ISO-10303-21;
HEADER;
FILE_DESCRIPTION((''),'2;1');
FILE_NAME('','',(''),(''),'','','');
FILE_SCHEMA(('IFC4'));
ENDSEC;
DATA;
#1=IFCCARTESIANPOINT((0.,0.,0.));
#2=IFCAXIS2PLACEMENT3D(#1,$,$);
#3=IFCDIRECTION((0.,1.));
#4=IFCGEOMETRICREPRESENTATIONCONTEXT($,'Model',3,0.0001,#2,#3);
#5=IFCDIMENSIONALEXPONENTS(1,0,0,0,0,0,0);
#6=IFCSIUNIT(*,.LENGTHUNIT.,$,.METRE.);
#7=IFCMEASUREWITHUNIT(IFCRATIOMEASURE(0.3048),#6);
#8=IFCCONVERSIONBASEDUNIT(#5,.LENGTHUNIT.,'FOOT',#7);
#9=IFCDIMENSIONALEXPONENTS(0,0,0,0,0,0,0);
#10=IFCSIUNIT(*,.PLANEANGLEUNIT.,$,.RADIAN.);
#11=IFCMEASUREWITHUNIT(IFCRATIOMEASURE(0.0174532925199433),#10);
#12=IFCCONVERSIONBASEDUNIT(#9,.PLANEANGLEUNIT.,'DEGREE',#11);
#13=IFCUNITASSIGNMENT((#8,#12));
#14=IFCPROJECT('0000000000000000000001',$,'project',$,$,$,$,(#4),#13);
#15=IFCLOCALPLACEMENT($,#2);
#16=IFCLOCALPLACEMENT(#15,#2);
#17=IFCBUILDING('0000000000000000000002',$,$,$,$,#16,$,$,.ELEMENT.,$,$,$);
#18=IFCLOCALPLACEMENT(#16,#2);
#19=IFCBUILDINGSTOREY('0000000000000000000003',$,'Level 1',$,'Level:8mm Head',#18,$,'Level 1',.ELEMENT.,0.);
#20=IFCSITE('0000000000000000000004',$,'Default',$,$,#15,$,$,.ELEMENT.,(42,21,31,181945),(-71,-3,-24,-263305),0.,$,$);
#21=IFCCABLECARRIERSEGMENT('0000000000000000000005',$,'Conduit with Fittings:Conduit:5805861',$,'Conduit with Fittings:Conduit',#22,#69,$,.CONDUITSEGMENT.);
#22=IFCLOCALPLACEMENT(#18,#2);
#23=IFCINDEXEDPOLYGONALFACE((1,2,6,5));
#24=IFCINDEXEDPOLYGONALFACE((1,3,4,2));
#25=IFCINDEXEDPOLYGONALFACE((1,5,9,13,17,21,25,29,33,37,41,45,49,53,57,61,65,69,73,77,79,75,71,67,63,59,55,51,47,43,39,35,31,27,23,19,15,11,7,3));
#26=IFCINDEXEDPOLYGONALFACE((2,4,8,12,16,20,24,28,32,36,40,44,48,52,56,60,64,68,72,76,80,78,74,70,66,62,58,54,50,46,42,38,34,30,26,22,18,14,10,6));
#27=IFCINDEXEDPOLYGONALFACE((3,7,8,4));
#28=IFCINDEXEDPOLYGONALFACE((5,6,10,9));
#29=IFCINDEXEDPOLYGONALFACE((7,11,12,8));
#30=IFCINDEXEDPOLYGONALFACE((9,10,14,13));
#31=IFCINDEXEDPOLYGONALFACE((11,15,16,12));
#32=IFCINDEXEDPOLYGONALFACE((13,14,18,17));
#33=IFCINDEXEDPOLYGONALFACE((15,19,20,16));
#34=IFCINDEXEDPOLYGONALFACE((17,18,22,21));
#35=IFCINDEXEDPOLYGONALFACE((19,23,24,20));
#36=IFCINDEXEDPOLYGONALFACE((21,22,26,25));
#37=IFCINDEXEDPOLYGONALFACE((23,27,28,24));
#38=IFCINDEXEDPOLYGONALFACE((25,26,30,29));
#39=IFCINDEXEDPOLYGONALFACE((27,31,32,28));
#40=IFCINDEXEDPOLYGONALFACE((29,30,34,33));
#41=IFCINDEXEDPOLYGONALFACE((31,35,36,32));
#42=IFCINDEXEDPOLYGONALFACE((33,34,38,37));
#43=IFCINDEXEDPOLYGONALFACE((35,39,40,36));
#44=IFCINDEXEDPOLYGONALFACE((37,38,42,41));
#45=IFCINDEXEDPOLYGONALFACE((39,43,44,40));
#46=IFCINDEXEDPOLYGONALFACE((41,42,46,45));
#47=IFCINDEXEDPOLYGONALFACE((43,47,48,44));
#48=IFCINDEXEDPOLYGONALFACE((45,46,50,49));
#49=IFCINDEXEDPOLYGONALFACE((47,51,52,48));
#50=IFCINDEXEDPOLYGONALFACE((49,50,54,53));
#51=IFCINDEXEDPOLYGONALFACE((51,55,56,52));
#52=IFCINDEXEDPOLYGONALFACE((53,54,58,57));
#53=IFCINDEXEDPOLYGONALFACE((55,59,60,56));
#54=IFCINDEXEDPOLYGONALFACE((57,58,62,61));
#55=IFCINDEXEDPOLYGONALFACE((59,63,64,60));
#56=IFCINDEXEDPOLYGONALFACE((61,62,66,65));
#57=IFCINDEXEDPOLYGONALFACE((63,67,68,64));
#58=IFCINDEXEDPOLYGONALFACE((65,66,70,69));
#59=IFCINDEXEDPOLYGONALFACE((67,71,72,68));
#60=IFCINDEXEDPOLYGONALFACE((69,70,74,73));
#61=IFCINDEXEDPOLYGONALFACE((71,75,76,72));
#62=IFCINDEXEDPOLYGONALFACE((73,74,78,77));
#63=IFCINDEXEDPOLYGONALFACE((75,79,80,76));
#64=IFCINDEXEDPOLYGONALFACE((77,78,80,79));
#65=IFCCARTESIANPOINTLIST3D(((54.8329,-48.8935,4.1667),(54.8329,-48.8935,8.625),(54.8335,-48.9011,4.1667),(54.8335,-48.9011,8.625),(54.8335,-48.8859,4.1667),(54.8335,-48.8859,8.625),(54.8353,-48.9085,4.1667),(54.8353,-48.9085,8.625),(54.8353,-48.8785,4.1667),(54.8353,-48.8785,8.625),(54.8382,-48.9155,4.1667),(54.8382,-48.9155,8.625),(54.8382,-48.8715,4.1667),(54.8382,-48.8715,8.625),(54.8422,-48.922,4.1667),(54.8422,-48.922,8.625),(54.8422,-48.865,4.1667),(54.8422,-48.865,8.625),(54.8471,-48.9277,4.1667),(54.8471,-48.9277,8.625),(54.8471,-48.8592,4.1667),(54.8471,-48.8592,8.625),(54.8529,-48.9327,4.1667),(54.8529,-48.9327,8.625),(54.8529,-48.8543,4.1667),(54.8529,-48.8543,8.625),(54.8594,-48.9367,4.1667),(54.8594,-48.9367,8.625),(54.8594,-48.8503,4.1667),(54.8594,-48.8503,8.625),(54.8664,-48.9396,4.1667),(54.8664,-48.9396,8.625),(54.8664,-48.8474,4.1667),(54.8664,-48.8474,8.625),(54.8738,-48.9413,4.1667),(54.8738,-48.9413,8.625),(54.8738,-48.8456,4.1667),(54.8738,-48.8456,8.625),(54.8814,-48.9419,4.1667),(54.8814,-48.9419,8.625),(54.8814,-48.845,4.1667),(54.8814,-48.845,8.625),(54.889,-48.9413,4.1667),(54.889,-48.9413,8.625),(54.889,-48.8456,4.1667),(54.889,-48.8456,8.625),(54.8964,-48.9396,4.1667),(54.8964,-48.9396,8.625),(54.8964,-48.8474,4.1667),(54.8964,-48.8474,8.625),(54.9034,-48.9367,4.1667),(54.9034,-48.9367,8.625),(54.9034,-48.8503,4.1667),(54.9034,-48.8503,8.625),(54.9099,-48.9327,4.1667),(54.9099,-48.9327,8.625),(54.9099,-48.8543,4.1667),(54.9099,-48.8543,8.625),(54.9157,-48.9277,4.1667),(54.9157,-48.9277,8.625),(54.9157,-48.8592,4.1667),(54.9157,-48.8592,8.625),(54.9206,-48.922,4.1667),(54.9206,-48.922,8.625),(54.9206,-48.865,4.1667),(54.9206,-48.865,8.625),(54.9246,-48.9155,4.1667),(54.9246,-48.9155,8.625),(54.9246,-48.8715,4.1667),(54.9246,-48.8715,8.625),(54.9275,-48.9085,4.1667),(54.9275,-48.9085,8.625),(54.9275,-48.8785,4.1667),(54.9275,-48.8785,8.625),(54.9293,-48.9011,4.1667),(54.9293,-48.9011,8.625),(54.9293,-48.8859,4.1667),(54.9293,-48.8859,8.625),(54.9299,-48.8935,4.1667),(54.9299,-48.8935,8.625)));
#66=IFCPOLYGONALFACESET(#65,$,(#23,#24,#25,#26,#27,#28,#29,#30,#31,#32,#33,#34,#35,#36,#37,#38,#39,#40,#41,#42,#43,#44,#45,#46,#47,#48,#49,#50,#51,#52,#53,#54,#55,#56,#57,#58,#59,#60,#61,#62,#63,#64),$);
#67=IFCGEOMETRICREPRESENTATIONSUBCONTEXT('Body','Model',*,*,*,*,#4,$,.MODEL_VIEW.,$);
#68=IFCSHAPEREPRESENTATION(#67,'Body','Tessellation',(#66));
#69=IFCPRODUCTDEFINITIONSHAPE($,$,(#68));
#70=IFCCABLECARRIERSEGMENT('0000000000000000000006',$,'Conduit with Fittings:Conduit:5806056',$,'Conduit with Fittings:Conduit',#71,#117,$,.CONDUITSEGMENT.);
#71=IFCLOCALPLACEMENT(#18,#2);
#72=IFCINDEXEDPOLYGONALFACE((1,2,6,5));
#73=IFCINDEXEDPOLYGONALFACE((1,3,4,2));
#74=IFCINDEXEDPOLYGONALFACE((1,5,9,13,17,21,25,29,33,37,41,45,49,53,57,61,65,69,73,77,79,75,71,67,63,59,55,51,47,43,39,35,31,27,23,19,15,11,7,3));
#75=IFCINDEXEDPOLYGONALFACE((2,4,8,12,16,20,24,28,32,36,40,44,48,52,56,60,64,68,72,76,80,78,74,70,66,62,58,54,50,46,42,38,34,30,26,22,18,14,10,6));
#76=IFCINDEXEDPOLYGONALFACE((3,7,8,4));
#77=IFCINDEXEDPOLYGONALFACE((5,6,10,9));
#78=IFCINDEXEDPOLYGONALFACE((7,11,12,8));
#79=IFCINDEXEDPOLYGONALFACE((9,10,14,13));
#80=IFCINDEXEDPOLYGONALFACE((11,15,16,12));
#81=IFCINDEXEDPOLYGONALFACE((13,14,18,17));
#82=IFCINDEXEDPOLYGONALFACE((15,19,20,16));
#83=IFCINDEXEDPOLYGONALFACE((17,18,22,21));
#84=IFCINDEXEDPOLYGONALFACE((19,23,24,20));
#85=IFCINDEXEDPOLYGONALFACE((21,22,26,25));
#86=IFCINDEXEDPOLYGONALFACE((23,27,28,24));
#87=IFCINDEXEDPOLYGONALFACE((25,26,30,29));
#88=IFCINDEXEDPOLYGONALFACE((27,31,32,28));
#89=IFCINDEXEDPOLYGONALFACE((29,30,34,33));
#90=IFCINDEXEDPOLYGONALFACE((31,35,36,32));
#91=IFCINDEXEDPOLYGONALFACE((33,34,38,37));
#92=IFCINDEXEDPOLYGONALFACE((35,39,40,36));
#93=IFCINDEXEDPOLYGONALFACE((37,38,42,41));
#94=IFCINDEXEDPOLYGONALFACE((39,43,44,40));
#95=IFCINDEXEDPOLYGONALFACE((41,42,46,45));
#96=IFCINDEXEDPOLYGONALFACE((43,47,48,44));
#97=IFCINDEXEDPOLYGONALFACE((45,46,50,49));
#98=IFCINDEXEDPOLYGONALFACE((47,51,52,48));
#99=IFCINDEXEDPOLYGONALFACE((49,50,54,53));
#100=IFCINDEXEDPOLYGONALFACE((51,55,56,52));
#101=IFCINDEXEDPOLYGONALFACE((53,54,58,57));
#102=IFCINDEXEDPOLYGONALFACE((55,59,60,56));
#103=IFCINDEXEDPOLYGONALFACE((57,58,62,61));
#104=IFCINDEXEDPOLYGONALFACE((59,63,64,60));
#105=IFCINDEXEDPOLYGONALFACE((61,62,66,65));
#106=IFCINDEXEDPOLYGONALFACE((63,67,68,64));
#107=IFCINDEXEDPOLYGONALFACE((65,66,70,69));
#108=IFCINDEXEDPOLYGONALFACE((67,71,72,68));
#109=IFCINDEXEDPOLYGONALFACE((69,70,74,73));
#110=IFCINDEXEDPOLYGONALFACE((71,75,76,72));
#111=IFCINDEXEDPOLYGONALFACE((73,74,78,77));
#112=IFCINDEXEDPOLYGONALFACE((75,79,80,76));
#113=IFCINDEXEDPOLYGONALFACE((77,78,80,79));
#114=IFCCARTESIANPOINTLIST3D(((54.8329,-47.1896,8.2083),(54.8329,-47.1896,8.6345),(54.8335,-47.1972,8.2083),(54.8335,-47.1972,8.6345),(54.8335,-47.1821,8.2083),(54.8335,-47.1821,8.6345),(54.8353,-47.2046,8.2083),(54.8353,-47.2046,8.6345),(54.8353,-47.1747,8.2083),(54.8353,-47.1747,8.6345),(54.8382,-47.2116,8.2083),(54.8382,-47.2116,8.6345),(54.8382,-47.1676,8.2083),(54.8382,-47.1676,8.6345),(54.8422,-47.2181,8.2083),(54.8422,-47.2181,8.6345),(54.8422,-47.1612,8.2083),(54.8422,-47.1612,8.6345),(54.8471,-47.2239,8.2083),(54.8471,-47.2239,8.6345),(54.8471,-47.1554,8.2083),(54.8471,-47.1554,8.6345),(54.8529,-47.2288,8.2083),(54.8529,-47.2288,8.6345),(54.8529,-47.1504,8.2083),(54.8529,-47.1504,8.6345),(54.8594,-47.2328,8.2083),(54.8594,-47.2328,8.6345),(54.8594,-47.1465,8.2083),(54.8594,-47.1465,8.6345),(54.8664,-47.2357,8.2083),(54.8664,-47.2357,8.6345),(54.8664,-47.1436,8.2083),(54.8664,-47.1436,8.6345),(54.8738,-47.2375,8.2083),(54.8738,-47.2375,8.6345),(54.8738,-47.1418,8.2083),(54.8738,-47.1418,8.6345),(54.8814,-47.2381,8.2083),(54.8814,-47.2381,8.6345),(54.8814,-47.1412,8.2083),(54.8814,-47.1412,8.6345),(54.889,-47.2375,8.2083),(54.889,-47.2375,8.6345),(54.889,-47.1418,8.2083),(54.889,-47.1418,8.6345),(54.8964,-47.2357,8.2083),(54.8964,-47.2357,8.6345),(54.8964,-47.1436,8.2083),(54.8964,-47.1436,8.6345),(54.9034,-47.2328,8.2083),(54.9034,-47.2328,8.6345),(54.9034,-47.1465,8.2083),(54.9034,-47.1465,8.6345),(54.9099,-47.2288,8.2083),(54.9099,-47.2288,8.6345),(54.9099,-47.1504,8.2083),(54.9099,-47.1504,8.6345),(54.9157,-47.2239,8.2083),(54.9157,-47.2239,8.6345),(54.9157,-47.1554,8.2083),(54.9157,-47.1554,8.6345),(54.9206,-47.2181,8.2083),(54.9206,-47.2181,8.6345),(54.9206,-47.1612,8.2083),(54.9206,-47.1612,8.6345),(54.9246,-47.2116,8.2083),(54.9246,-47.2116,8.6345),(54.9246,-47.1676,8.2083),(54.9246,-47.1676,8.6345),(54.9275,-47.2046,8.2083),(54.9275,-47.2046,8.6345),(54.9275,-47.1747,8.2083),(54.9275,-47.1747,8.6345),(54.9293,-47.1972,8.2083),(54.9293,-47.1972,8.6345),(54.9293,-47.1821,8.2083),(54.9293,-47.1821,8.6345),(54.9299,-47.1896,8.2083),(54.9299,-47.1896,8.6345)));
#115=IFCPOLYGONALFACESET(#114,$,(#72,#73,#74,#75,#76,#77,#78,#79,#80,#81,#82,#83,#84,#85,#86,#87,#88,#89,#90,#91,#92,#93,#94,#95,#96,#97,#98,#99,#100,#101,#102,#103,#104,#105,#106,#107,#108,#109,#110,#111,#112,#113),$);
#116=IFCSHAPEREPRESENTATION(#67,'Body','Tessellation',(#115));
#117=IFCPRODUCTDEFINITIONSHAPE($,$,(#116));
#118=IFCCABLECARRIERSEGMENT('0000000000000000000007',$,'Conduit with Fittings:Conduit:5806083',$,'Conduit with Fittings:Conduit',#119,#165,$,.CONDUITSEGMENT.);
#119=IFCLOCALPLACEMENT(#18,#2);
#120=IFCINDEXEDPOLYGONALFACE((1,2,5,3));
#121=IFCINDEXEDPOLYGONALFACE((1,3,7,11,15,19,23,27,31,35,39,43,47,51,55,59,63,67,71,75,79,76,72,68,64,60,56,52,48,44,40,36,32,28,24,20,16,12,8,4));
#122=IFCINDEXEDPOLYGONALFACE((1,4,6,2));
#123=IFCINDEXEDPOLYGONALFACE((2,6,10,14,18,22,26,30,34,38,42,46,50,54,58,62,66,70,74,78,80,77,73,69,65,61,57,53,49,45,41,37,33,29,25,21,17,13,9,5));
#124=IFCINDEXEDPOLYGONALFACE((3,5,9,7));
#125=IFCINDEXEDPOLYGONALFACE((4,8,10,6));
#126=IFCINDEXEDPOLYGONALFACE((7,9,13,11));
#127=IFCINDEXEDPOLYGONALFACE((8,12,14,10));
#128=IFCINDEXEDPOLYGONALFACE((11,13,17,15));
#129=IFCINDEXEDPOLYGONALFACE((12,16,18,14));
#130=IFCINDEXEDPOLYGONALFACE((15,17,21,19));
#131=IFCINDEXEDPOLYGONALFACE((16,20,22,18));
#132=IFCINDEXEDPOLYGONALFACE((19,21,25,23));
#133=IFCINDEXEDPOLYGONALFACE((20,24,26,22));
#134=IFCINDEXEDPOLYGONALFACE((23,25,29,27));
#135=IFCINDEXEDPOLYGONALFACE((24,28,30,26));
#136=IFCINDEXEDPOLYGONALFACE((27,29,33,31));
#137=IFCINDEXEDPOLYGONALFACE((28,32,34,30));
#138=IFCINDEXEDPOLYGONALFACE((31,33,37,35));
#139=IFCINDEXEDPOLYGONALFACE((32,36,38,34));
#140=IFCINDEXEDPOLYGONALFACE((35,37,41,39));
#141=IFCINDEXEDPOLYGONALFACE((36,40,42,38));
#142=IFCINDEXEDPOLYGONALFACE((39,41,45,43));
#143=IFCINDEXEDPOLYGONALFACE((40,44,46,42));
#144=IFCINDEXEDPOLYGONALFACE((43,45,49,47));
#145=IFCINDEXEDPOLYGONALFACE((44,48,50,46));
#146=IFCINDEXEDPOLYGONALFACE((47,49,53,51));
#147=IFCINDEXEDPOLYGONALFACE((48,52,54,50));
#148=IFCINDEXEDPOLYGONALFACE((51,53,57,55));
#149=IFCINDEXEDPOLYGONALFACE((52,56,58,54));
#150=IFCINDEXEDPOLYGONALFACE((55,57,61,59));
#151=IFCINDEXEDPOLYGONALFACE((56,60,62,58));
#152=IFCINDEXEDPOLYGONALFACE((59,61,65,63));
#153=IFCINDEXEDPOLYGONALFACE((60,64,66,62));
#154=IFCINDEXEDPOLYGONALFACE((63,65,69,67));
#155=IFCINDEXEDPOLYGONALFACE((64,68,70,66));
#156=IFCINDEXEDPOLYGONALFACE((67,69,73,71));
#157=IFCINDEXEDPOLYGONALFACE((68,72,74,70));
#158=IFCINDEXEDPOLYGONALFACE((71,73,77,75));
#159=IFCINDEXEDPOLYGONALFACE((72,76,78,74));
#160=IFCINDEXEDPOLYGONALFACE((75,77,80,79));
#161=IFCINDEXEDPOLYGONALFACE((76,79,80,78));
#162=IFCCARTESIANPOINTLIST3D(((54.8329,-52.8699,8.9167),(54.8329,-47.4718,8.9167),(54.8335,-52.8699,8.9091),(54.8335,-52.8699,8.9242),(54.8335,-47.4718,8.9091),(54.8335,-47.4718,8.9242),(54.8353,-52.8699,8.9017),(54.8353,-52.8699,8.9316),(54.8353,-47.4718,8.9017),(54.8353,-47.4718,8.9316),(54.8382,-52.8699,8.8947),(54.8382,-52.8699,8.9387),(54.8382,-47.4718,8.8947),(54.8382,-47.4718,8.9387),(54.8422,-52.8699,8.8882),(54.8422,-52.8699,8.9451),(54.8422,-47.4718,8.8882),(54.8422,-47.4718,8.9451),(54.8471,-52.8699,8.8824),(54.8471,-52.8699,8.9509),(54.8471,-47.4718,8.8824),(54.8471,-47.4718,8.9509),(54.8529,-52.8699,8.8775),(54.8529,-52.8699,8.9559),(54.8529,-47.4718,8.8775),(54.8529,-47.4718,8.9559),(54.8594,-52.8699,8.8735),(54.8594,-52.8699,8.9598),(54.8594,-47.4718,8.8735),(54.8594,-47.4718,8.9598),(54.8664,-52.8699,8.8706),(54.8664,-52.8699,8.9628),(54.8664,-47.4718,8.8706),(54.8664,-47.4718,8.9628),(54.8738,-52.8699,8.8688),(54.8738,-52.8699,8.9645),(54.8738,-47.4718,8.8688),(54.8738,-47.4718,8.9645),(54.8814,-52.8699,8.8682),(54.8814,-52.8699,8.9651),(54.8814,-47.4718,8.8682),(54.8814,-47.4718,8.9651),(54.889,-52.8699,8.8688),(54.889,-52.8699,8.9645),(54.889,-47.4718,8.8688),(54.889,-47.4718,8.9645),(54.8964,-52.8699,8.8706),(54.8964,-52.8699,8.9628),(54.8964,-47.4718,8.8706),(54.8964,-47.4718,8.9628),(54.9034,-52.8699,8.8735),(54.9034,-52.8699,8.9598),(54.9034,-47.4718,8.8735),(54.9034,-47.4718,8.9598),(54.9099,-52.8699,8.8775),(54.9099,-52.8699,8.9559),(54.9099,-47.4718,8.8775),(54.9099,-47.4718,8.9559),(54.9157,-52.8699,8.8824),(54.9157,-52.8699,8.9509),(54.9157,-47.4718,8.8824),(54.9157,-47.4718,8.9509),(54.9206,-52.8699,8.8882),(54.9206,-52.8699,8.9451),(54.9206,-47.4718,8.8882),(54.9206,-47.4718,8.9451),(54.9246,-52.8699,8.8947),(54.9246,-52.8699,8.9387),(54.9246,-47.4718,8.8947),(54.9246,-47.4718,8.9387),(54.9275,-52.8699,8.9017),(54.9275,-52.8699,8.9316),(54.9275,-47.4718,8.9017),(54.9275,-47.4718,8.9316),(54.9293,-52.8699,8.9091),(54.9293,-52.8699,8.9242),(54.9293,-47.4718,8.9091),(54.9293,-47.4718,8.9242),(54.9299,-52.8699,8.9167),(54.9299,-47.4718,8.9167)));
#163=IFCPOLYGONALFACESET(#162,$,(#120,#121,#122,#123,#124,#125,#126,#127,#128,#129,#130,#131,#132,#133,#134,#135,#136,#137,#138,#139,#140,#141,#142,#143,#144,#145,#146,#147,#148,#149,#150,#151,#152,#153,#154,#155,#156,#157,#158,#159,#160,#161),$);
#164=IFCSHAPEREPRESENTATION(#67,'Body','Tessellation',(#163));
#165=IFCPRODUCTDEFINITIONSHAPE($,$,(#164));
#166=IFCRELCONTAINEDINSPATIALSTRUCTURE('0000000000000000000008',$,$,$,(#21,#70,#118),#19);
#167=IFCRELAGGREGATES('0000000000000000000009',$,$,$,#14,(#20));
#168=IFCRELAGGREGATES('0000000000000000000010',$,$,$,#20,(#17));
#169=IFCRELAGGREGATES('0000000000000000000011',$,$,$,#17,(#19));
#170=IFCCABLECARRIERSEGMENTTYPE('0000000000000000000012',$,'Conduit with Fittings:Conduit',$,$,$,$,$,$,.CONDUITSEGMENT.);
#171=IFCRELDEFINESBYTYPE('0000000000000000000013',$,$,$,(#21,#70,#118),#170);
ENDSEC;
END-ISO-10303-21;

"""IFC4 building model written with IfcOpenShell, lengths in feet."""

from ifc_helpers import new_model, entity, si_unit, converted_unit, direction, frame, origin, place, context, subcontext, project, spatial, indexed_curve, outline, extrude, type_object, element, save


model = new_model("IFC4")

# Units and contexts
model_context = context("Model", 3, precision=0.0001, world=origin(), true_north=direction((0.0, 1.0)))
body_context = subcontext(model_context, "Body", "Model", "MODEL_VIEW")
ifc_project = project(units=[converted_unit("LENGTHUNIT", "FOOT", entity("IfcRatioMeasure", 0.3048), si_unit("LENGTHUNIT", "METRE"), dimensions=[1, 0, 0, 0, 0, 0, 0]), converted_unit("PLANEANGLEUNIT", "DEGREE", entity("IfcRatioMeasure", 0.0174532925199433), si_unit("PLANEANGLEUNIT", "RADIAN"), dimensions=[0, 0, 0, 0, 0, 0, 0])], contexts=[model_context])

# Site, building, storey
site_placement = place(None, origin())
site = spatial("IfcSite", under=ifc_project, at=site_placement, Name="Default", CompositionType="ELEMENT", RefLatitude=(42, 21, 31, 181945), RefLongitude=(-71, -3, -24, -263305), RefElevation=0.0)
building_placement = place(site_placement, origin())
building = spatial("IfcBuilding", under=site, at=building_placement, CompositionType="ELEMENT")
storey_placement = place(building_placement, origin())
storey = spatial("IfcBuildingStorey", under=building, at=storey_placement, Name="Level 1", ObjectType="Level:8mm Head", LongName="Level 1", CompositionType="ELEMENT", Elevation=0.0)

# Cable carrier segments
cable_carrier_segment_type_1 = type_object("IfcCableCarrierSegmentType", Name="Conduit with Fittings:Conduit", PredefinedType="CONDUITSEGMENT")
cable_carrier_segment_1_placement = place(storey_placement, origin())
element("IfcCableCarrierSegment", 1, at=cable_carrier_segment_1_placement, inside=storey, type_object=cable_carrier_segment_type_1, Name="Conduit with Fittings:Conduit:5805861", ObjectType="Conduit with Fittings:Conduit", PredefinedType="CONDUITSEGMENT", context=body_context, shape_type="SweptSolid", body=[
    extrude(outline(indexed_curve([(0.0485, 0.0), (0.0479, 0.0076), (0.0461, 0.015), (0.0432, 0.022), (0.0392, 0.0285), (0.0343, 0.0343), (0.0285, 0.0392), (0.022, 0.0432), (0.015, 0.0461), (0.0076, 0.0479), (0.0, 0.0485), (-0.0076, 0.0479), (-0.015, 0.0461), (-0.022, 0.0432), (-0.0285, 0.0392), (-0.0343, 0.0343), (-0.0392, 0.0285), (-0.0432, 0.022), (-0.0461, 0.015), (-0.0479, 0.0076), (-0.0485, 0.0), (-0.0479, -0.0076), (-0.0461, -0.015), (-0.0432, -0.022), (-0.0392, -0.0285), (-0.0343, -0.0343), (-0.0285, -0.0392), (-0.022, -0.0432), (-0.015, -0.0461), (-0.0076, -0.0479), (0.0, -0.0485), (0.0076, -0.0479), (0.015, -0.0461), (0.022, -0.0432), (0.0285, -0.0392), (0.0343, -0.0343), (0.0392, -0.0285), (0.0432, -0.022), (0.0461, -0.015), (0.0479, -0.0076), (0.0485, 0.0)], self_intersect=False)), frame((54.8814, -48.8935, 4.1667)), (0.0, 0.0, 1.0), 4.4583),
])
cable_carrier_segment_2_placement = place(storey_placement, origin())
element("IfcCableCarrierSegment", 2, at=cable_carrier_segment_2_placement, inside=storey, type_object=cable_carrier_segment_type_1, Name="Conduit with Fittings:Conduit:5806056", ObjectType="Conduit with Fittings:Conduit", PredefinedType="CONDUITSEGMENT", context=body_context, shape_type="SweptSolid", body=[
    extrude(outline(indexed_curve([(0.0485, 0.0), (0.0479, 0.0076), (0.0461, 0.015), (0.0432, 0.022), (0.0392, 0.0285), (0.0343, 0.0343), (0.0285, 0.0392), (0.022, 0.0432), (0.015, 0.0461), (0.0076, 0.0479), (0.0, 0.0485), (-0.0076, 0.0479), (-0.015, 0.0461), (-0.022, 0.0432), (-0.0285, 0.0392), (-0.0343, 0.0343), (-0.0392, 0.0285), (-0.0432, 0.022), (-0.0461, 0.015), (-0.0479, 0.0076), (-0.0485, 0.0), (-0.0479, -0.0076), (-0.0461, -0.015), (-0.0432, -0.022), (-0.0392, -0.0285), (-0.0343, -0.0343), (-0.0285, -0.0392), (-0.022, -0.0432), (-0.015, -0.0461), (-0.0076, -0.0479), (0.0, -0.0485), (0.0076, -0.0479), (0.015, -0.0461), (0.022, -0.0432), (0.0285, -0.0392), (0.0343, -0.0343), (0.0392, -0.0285), (0.0432, -0.022), (0.0461, -0.015), (0.0479, -0.0076), (0.0485, 0.0)], self_intersect=False)), frame((54.8814, -47.1896, 8.2083)), (0.0, 0.0, 1.0), 0.4262),
])
cable_carrier_segment_3_placement = place(storey_placement, origin())
element("IfcCableCarrierSegment", 3, at=cable_carrier_segment_3_placement, inside=storey, type_object=cable_carrier_segment_type_1, Name="Conduit with Fittings:Conduit:5806083", ObjectType="Conduit with Fittings:Conduit", PredefinedType="CONDUITSEGMENT", context=body_context, shape_type="SweptSolid", body=[
    extrude(outline(indexed_curve([(0.0485, 0.0), (0.0479, 0.0076), (0.0461, 0.015), (0.0432, 0.022), (0.0392, 0.0285), (0.0343, 0.0343), (0.0285, 0.0392), (0.022, 0.0432), (0.015, 0.0461), (0.0076, 0.0479), (0.0, 0.0485), (-0.0076, 0.0479), (-0.015, 0.0461), (-0.022, 0.0432), (-0.0285, 0.0392), (-0.0343, 0.0343), (-0.0392, 0.0285), (-0.0432, 0.022), (-0.0461, 0.015), (-0.0479, 0.0076), (-0.0485, 0.0), (-0.0479, -0.0076), (-0.0461, -0.015), (-0.0432, -0.022), (-0.0392, -0.0285), (-0.0343, -0.0343), (-0.0285, -0.0392), (-0.022, -0.0432), (-0.015, -0.0461), (-0.0076, -0.0479), (0.0, -0.0485), (0.0076, -0.0479), (0.015, -0.0461), (0.022, -0.0432), (0.0285, -0.0392), (0.0343, -0.0343), (0.0392, -0.0285), (0.0432, -0.022), (0.0461, -0.015), (0.0479, -0.0076), (0.0485, 0.0)], self_intersect=False)), frame((54.8814, -52.8699, 8.9167), z_axis=(0.0, 1.0, 0.0), x_axis=(-1.0, 0.0, 0.0)), (0.0, 0.0, 1.0), 5.3981),
])

save(model, "model.ifc")
